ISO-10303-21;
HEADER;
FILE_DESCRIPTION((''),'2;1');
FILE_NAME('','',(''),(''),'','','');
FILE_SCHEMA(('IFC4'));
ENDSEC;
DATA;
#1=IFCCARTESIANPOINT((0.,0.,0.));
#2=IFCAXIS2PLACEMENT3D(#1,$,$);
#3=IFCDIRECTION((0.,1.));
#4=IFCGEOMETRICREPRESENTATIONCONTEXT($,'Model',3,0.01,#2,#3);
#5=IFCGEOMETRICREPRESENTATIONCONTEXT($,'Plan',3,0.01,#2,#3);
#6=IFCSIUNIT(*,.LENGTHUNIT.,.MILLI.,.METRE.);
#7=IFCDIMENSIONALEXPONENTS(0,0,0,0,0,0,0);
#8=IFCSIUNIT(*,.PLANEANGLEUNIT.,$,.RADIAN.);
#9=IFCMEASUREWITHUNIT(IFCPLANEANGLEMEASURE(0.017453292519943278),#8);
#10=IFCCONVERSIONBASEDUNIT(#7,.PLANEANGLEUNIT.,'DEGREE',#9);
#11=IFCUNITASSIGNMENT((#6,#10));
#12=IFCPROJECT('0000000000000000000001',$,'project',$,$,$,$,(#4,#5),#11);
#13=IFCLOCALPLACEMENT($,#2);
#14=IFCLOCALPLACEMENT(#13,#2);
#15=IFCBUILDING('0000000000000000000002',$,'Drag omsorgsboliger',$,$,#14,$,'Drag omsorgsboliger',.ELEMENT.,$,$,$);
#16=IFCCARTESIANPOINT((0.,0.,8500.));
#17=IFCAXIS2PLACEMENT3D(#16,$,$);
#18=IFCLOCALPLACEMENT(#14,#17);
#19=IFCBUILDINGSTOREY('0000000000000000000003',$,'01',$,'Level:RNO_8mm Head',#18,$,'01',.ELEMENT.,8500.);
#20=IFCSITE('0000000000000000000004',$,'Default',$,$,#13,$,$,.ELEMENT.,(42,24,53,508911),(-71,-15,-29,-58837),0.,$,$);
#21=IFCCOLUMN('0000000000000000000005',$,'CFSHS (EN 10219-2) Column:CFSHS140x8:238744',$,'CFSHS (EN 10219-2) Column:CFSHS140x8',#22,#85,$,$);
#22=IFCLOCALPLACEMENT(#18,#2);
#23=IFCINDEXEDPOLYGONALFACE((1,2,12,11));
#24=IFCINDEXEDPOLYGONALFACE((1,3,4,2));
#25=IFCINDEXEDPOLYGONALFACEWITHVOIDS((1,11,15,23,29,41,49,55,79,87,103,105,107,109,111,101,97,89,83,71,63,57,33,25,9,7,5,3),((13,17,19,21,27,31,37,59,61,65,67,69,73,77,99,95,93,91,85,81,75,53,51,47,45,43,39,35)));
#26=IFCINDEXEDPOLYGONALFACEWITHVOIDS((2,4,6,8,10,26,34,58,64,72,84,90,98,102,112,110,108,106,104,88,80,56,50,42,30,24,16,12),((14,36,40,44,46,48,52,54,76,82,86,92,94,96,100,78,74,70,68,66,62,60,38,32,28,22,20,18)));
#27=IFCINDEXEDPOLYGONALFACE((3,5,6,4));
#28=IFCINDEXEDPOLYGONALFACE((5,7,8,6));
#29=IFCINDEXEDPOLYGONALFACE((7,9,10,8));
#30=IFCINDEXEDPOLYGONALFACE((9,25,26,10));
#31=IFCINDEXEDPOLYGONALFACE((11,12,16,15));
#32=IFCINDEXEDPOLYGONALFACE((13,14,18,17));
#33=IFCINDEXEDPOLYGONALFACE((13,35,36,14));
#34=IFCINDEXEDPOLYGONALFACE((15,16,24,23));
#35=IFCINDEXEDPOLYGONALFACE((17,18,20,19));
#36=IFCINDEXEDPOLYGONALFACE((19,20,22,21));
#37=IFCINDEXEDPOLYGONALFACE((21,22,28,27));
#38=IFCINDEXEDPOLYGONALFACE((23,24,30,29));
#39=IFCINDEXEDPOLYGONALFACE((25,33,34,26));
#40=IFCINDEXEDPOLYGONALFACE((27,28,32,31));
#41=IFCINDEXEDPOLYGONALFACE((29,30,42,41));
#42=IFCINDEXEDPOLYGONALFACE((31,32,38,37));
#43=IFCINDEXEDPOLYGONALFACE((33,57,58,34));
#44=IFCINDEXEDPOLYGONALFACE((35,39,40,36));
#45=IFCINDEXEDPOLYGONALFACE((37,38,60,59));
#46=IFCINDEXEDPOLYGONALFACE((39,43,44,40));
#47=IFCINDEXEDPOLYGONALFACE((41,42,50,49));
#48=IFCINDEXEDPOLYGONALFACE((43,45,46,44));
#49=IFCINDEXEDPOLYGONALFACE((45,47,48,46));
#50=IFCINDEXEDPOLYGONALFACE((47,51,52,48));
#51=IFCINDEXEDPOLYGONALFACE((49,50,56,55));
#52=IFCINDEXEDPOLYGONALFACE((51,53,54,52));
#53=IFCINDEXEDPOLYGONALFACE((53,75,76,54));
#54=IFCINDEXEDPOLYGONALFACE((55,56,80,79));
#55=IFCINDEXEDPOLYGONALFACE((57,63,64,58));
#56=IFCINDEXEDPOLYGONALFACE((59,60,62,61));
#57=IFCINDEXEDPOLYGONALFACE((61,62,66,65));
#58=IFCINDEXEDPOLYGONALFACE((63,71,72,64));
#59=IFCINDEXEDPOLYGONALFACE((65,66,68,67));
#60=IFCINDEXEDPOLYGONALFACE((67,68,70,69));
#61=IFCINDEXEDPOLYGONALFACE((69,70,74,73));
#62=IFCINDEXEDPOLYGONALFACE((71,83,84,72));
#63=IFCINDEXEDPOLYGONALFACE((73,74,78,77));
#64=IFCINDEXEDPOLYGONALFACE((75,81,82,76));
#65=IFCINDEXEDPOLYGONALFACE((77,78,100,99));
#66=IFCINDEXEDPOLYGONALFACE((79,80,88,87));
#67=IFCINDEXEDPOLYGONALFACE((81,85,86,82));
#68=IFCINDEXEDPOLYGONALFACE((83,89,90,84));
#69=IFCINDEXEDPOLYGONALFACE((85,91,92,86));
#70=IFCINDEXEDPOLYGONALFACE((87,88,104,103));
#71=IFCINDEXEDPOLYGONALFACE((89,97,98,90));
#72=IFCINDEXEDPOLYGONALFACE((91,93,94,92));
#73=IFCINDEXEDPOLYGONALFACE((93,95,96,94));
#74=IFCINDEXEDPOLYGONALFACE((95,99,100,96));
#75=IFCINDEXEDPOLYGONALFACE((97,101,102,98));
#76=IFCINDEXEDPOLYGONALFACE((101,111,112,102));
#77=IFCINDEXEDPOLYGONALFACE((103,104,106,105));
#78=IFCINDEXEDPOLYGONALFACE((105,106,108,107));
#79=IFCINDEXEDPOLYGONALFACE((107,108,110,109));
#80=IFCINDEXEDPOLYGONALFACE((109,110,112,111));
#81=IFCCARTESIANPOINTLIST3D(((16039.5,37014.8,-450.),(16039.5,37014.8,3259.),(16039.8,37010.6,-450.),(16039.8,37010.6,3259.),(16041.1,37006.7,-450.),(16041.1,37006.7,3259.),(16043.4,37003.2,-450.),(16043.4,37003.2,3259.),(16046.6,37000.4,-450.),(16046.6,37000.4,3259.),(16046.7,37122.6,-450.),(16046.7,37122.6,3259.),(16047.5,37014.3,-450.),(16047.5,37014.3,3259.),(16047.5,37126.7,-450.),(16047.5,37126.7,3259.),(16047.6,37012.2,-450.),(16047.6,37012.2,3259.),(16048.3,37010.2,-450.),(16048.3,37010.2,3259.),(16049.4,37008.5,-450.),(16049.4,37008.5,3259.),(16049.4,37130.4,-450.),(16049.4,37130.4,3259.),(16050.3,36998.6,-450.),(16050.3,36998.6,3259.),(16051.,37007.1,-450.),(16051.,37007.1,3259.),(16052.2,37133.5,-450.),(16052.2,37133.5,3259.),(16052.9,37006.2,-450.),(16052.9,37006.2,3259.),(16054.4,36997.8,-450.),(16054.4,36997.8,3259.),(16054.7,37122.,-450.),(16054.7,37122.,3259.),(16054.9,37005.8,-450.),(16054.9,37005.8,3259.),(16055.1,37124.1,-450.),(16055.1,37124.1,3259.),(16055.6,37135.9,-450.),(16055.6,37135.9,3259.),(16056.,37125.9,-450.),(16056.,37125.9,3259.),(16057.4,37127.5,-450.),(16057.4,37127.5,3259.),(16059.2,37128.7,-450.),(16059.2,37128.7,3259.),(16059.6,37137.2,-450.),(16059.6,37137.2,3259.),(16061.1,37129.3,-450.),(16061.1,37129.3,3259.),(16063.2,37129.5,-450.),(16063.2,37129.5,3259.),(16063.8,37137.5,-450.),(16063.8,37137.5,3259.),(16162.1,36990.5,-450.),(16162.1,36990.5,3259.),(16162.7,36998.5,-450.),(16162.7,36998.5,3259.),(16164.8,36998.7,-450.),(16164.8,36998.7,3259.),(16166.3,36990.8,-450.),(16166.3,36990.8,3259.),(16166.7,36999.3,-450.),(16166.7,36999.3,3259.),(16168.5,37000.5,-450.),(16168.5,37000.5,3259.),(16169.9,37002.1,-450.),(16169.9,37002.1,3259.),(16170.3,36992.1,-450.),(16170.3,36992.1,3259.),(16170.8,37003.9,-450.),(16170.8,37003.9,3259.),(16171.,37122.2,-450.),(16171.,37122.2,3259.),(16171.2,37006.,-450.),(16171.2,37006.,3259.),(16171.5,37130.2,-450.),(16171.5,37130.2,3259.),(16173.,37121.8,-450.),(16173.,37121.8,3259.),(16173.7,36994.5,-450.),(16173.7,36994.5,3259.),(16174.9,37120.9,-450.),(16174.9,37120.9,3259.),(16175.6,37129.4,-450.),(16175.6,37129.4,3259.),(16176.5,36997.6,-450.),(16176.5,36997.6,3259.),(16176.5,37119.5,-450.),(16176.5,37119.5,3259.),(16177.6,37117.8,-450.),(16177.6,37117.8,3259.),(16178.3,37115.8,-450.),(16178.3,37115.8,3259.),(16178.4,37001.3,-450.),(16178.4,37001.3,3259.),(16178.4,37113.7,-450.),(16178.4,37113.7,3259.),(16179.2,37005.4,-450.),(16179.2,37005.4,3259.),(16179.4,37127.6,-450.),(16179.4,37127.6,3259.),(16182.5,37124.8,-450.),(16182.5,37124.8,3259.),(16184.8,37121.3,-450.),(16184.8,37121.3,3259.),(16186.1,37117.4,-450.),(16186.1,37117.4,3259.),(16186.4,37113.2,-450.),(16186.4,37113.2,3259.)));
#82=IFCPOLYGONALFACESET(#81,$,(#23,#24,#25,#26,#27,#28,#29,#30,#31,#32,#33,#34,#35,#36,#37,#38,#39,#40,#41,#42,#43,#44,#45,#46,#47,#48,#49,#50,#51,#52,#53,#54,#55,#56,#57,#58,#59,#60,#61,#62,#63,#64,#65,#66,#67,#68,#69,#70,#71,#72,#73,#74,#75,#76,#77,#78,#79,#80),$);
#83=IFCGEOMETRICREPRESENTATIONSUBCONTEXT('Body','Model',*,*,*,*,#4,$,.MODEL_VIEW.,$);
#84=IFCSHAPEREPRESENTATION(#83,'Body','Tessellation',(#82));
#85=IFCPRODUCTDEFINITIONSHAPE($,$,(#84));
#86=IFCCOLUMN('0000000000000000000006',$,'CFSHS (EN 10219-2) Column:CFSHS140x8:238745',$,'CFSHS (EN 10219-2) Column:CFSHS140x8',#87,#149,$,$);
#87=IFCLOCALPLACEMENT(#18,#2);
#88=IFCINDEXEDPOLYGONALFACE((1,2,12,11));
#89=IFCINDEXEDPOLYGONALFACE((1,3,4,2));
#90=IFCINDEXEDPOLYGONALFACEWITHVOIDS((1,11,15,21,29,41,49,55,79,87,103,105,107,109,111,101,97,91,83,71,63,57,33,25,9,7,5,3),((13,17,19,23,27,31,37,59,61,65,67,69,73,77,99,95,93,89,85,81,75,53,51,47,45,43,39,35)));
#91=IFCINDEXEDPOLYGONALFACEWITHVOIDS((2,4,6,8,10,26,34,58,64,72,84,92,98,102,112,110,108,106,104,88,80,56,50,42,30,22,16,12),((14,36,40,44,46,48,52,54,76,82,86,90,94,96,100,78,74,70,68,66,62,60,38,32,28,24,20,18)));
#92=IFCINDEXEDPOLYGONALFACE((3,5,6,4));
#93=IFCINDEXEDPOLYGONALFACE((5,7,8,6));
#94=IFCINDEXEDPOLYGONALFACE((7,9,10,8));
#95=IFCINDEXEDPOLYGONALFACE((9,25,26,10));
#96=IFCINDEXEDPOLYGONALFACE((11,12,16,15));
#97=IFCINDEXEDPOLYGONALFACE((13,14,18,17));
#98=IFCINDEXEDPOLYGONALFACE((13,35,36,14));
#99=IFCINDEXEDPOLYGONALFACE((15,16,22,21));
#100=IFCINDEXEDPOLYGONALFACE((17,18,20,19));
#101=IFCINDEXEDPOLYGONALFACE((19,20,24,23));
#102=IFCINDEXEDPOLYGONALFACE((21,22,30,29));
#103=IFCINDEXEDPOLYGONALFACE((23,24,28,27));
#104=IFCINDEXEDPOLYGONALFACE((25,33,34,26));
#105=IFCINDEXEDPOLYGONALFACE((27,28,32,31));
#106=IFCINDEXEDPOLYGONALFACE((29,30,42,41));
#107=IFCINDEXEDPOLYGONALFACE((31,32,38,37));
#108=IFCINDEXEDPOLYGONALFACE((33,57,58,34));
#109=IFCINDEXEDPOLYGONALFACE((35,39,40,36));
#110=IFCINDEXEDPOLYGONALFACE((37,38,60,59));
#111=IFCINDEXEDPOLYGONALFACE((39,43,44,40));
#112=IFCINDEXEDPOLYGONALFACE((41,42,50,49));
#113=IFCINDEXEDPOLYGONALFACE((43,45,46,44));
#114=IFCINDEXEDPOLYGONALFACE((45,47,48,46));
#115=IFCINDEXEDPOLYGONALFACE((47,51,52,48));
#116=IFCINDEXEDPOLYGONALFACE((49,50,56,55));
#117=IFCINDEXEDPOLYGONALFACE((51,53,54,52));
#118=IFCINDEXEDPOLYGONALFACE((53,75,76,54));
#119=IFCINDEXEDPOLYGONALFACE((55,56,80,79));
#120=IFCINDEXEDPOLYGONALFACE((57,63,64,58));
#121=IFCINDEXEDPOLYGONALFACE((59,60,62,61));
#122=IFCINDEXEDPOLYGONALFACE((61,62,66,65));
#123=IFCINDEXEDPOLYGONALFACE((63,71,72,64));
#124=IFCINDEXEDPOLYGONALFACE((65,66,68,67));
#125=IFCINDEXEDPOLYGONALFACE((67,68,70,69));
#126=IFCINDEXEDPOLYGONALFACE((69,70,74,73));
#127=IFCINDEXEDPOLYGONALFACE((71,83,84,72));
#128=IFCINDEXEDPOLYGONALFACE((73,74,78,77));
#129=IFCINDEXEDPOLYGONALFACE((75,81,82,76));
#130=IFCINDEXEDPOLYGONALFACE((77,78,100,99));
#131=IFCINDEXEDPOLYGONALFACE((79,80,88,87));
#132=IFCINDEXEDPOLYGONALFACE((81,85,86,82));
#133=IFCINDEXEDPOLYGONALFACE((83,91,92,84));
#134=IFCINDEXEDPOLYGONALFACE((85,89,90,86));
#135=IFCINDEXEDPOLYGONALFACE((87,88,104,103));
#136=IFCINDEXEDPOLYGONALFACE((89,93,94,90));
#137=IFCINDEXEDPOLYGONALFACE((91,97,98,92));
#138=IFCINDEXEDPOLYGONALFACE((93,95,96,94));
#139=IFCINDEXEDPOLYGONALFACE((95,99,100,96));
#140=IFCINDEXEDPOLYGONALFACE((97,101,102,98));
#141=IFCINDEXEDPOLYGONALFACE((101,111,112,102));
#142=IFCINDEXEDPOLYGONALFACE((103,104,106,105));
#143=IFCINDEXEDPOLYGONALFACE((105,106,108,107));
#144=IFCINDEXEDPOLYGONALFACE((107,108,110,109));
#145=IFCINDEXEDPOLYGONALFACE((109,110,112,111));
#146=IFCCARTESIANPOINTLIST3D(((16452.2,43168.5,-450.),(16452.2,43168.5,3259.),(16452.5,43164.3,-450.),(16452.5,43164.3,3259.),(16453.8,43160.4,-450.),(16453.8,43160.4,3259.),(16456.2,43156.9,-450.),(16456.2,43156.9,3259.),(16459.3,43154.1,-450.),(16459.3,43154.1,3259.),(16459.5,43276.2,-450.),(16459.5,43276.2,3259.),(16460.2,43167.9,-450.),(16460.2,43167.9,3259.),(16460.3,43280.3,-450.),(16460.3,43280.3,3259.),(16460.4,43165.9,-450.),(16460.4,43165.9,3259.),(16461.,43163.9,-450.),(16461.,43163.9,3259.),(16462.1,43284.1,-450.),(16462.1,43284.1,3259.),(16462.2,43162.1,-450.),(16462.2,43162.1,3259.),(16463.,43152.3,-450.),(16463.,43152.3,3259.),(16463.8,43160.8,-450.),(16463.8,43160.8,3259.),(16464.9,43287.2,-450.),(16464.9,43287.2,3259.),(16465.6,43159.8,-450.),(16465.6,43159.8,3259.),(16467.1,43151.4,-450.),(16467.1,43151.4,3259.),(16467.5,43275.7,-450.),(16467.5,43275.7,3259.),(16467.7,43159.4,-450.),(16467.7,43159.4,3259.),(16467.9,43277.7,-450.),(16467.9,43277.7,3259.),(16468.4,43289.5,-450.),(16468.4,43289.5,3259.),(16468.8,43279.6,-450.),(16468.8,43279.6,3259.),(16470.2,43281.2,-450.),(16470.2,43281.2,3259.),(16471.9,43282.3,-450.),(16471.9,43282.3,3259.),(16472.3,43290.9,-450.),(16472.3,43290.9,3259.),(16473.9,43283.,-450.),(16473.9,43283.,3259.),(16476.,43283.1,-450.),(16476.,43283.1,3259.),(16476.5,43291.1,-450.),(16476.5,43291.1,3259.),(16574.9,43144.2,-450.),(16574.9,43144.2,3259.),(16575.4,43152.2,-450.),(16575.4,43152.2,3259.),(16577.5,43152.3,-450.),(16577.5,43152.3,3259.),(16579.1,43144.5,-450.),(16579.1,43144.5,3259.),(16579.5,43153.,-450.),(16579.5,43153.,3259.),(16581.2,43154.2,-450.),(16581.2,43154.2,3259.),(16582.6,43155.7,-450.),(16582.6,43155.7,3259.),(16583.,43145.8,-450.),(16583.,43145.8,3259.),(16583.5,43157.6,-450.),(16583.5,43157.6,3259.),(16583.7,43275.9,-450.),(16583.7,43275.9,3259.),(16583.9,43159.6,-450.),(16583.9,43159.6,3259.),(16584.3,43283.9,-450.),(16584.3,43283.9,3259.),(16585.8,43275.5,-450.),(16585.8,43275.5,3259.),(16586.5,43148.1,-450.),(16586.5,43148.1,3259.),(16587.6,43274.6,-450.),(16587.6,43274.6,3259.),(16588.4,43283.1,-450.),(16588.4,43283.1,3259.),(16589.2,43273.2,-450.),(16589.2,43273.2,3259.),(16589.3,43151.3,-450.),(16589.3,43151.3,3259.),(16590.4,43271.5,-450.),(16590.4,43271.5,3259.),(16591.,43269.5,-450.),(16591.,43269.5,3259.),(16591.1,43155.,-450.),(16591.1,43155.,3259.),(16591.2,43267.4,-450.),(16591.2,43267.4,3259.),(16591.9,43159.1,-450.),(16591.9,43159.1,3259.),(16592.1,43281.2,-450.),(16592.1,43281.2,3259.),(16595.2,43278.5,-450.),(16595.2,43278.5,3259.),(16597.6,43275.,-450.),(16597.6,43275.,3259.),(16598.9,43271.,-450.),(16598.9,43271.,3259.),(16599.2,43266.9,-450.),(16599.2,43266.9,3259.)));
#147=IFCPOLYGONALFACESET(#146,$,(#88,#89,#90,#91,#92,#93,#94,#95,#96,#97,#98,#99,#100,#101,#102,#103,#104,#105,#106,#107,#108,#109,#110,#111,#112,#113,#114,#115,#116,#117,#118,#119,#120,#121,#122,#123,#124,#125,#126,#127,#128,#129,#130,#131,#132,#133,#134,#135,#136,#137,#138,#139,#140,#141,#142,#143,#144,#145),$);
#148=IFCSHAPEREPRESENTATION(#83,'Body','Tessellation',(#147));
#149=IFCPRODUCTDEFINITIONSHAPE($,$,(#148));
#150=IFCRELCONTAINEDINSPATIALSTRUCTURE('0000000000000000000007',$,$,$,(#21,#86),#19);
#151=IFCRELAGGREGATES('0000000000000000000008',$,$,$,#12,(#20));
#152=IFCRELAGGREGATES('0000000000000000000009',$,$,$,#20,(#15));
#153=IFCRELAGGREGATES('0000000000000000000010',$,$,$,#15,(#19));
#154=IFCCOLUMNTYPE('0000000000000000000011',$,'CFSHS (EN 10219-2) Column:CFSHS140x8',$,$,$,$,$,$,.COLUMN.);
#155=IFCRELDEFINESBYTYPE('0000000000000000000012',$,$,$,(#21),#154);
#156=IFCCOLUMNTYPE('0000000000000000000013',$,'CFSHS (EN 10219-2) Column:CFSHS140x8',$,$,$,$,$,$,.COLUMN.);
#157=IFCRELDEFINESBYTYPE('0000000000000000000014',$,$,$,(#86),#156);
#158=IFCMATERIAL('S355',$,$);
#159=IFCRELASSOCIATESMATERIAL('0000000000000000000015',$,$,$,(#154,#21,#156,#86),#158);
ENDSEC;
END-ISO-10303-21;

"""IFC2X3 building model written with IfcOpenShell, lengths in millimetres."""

from ifc_helpers import new_model, entity, si_unit, converted_unit, direction, frame, frame_2d, origin, place, context, subcontext, project, spatial, polyline, circle_curve, parameter, trimmed, segment, composite_curve, outline, extrude, source, transform, mapped, material, type_object, type_shapes, element, save


model = new_model("IFC2X3")

# Units and contexts
model_context = context("Model", 3, precision=0.01, world=origin(), true_north=direction((0.0, 1.0)))
plan_context = context("Plan", 3, precision=0.01, world=origin(), true_north=direction((0.0, 1.0)))
body_context = subcontext(model_context, "Body", "Model", "MODEL_VIEW")
ifc_project = project(units=[si_unit("LENGTHUNIT", "METRE", prefix="MILLI"), converted_unit("PLANEANGLEUNIT", "DEGREE", entity("IfcPlaneAngleMeasure", 0.017453292519943278), si_unit("PLANEANGLEUNIT", "RADIAN"), dimensions=[0, 0, 0, 0, 0, 0, 0])], contexts=[model_context, plan_context])

# Site, building, storey
site_placement = place(None, origin())
site = spatial("IfcSite", under=ifc_project, at=site_placement, Name="Default", CompositionType="ELEMENT", RefLatitude=(42, 24, 53, 508911), RefLongitude=(-71, -15, -29, -58837), RefElevation=0.0)
building_placement = place(site_placement, origin())
building = spatial("IfcBuilding", under=site, at=building_placement, Name="Drag omsorgsboliger", LongName="Drag omsorgsboliger", CompositionType="ELEMENT")
storey_placement = place(building_placement, frame((0.0, 0.0, 8500.0)))
storey = spatial("IfcBuildingStorey", under=building, at=storey_placement, Name="01", ObjectType="Level:RNO_8mm Head", LongName="01", CompositionType="ELEMENT", Elevation=8500.0)

# Columns
ifc_material = material(Name="S355")
column_type_1 = type_object("IfcColumnType", Name="CFSHS (EN 10219-2) Column:CFSHS140x8", PredefinedType="COLUMN", material=ifc_material)
shared_shape_1 = source(origin(), body_context, "Body", "SweptSolid", [
    extrude(outline(composite_curve([segment(polyline([(-54.0, -70.0), (54.0, -70.0)]), True, "CONTINUOUS"), segment(trimmed(circle_curve(frame_2d((54.0, -54.0), x_axis=(-1.0, 0.0)), 16.0), [parameter(90.0)], [parameter(180.0)], True, "PARAMETER"), True, "CONTINUOUS"), segment(polyline([(70.0, -54.0), (70.0, 54.0)]), True, "CONTINUOUS"), segment(trimmed(circle_curve(frame_2d((54.0, 54.0), x_axis=(-1.0, 0.0)), 16.0), [parameter(180.0)], [parameter(270.0)], True, "PARAMETER"), True, "CONTINUOUS"), segment(polyline([(54.0, 70.0), (-54.0, 70.0)]), True, "CONTINUOUS"), segment(trimmed(circle_curve(frame_2d((-54.0, 54.0), x_axis=(-1.0, 0.0)), 16.0), [parameter(270.0)], [parameter(360.0)], True, "PARAMETER"), True, "CONTINUOUS"), segment(polyline([(-70.0, 54.0), (-70.0, -54.0)]), True, "CONTINUOUS"), segment(trimmed(circle_curve(frame_2d((-54.0, -54.0), x_axis=(-1.0, 0.0)), 16.0), [parameter(360.0)], [parameter(90.0)], True, "PARAMETER"), True, "CONTINUOUS")], self_intersect=False), holes=[composite_curve([segment(trimmed(circle_curve(frame_2d((-54.0, -54.0), x_axis=(-1.0, 0.0)), 8.0), [parameter(360.0)], [parameter(90.0)], True, "PARAMETER"), False, "CONTINUOUS"), segment(polyline([(-62.0, -54.0), (-62.0, 54.0)]), True, "CONTINUOUS"), segment(trimmed(circle_curve(frame_2d((-54.0, 54.0), x_axis=(-1.0, 0.0)), 8.0), [parameter(270.0)], [parameter(360.0)], True, "PARAMETER"), False, "CONTINUOUS"), segment(polyline([(-54.0, 62.0), (54.0, 62.0)]), True, "CONTINUOUS"), segment(trimmed(circle_curve(frame_2d((54.0, 54.0), x_axis=(-1.0, 0.0)), 8.0), [parameter(180.0)], [parameter(270.0)], True, "PARAMETER"), False, "CONTINUOUS"), segment(polyline([(62.0, 54.0), (62.0, -54.0)]), True, "CONTINUOUS"), segment(trimmed(circle_curve(frame_2d((54.0, -54.0), x_axis=(-1.0, 0.0)), 8.0), [parameter(90.0)], [parameter(180.0)], True, "PARAMETER"), False, "CONTINUOUS"), segment(polyline([(54.0, -62.0), (-54.0, -62.0)]), True, "CONTINUOUS")], self_intersect=False)]), frame((16113.0, 37064.0, 8050.0), z_axis=(0.0, 0.0, 1.0), x_axis=(-0.997758, 0.066923, 0.0)), (0.0, 0.0, 1.0), 3709.0),
])
type_shapes(column_type_1, [shared_shape_1])
column_1_placement = place(storey_placement, frame((0.0, 0.0, -8500.0)))
element("IfcColumn", 1, at=column_1_placement, inside=storey, type_object=column_type_1, material=ifc_material, Name="CFSHS (EN 10219-2) Column:CFSHS140x8:238744", ObjectType="CFSHS (EN 10219-2) Column:CFSHS140x8", context=body_context, shape_type="MappedRepresentation", body=[
    mapped(shared_shape_1, transform((0.0, 0.0, 0.0), scale=1.0)),
])
column_type_2 = type_object("IfcColumnType", Name="CFSHS (EN 10219-2) Column:CFSHS140x8", PredefinedType="COLUMN", material=ifc_material)
shared_shape_2 = source(origin(), body_context, "Body", "SweptSolid", [
    extrude(outline(composite_curve([segment(polyline([(-54.0, -70.0), (54.0, -70.0)]), True, "CONTINUOUS"), segment(trimmed(circle_curve(frame_2d((54.0, -54.0), x_axis=(-1.0, 0.0)), 16.0), [parameter(90.0)], [parameter(180.0)], True, "PARAMETER"), True, "CONTINUOUS"), segment(polyline([(70.0, -54.0), (70.0, 54.0)]), True, "CONTINUOUS"), segment(trimmed(circle_curve(frame_2d((54.0, 54.0), x_axis=(-1.0, 0.0)), 16.0), [parameter(180.0)], [parameter(270.0)], True, "PARAMETER"), True, "CONTINUOUS"), segment(polyline([(54.0, 70.0), (-54.0, 70.0)]), True, "CONTINUOUS"), segment(trimmed(circle_curve(frame_2d((-54.0, 54.0), x_axis=(-1.0, 0.0)), 16.0), [parameter(270.0)], [parameter(360.0)], True, "PARAMETER"), True, "CONTINUOUS"), segment(polyline([(-70.0, 54.0), (-70.0, -54.0)]), True, "CONTINUOUS"), segment(trimmed(circle_curve(frame_2d((-54.0, -54.0), x_axis=(-1.0, 0.0)), 16.0), [parameter(360.0)], [parameter(90.0)], True, "PARAMETER"), True, "CONTINUOUS")], self_intersect=False), holes=[composite_curve([segment(trimmed(circle_curve(frame_2d((-54.0, -54.0), x_axis=(-1.0, 0.0)), 8.0), [parameter(360.0)], [parameter(90.0)], True, "PARAMETER"), False, "CONTINUOUS"), segment(polyline([(-62.0, -54.0), (-62.0, 54.0)]), True, "CONTINUOUS"), segment(trimmed(circle_curve(frame_2d((-54.0, 54.0), x_axis=(-1.0, 0.0)), 8.0), [parameter(270.0)], [parameter(360.0)], True, "PARAMETER"), False, "CONTINUOUS"), segment(polyline([(-54.0, 62.0), (54.0, 62.0)]), True, "CONTINUOUS"), segment(trimmed(circle_curve(frame_2d((54.0, 54.0), x_axis=(-1.0, 0.0)), 8.0), [parameter(180.0)], [parameter(270.0)], True, "PARAMETER"), False, "CONTINUOUS"), segment(polyline([(62.0, 54.0), (62.0, -54.0)]), True, "CONTINUOUS"), segment(trimmed(circle_curve(frame_2d((54.0, -54.0), x_axis=(-1.0, 0.0)), 8.0), [parameter(90.0)], [parameter(180.0)], True, "PARAMETER"), False, "CONTINUOUS"), segment(polyline([(54.0, -62.0), (-54.0, -62.0)]), True, "CONTINUOUS")], self_intersect=False)]), frame((16525.7, 43217.7, 8050.0), z_axis=(0.0, 0.0, 1.0), x_axis=(-0.997758, 0.066923, 0.0)), (0.0, 0.0, 1.0), 3709.0),
])
type_shapes(column_type_2, [shared_shape_2])
column_2_placement = place(storey_placement, frame((0.0, 0.0, -8500.0)))
element("IfcColumn", 2, at=column_2_placement, inside=storey, type_object=column_type_2, material=ifc_material, Name="CFSHS (EN 10219-2) Column:CFSHS140x8:238745", ObjectType="CFSHS (EN 10219-2) Column:CFSHS140x8", context=body_context, shape_type="MappedRepresentation", body=[
    mapped(shared_shape_2, transform((0.0, 0.0, 0.0), scale=1.0)),
])

save(model, "model.ifc")
